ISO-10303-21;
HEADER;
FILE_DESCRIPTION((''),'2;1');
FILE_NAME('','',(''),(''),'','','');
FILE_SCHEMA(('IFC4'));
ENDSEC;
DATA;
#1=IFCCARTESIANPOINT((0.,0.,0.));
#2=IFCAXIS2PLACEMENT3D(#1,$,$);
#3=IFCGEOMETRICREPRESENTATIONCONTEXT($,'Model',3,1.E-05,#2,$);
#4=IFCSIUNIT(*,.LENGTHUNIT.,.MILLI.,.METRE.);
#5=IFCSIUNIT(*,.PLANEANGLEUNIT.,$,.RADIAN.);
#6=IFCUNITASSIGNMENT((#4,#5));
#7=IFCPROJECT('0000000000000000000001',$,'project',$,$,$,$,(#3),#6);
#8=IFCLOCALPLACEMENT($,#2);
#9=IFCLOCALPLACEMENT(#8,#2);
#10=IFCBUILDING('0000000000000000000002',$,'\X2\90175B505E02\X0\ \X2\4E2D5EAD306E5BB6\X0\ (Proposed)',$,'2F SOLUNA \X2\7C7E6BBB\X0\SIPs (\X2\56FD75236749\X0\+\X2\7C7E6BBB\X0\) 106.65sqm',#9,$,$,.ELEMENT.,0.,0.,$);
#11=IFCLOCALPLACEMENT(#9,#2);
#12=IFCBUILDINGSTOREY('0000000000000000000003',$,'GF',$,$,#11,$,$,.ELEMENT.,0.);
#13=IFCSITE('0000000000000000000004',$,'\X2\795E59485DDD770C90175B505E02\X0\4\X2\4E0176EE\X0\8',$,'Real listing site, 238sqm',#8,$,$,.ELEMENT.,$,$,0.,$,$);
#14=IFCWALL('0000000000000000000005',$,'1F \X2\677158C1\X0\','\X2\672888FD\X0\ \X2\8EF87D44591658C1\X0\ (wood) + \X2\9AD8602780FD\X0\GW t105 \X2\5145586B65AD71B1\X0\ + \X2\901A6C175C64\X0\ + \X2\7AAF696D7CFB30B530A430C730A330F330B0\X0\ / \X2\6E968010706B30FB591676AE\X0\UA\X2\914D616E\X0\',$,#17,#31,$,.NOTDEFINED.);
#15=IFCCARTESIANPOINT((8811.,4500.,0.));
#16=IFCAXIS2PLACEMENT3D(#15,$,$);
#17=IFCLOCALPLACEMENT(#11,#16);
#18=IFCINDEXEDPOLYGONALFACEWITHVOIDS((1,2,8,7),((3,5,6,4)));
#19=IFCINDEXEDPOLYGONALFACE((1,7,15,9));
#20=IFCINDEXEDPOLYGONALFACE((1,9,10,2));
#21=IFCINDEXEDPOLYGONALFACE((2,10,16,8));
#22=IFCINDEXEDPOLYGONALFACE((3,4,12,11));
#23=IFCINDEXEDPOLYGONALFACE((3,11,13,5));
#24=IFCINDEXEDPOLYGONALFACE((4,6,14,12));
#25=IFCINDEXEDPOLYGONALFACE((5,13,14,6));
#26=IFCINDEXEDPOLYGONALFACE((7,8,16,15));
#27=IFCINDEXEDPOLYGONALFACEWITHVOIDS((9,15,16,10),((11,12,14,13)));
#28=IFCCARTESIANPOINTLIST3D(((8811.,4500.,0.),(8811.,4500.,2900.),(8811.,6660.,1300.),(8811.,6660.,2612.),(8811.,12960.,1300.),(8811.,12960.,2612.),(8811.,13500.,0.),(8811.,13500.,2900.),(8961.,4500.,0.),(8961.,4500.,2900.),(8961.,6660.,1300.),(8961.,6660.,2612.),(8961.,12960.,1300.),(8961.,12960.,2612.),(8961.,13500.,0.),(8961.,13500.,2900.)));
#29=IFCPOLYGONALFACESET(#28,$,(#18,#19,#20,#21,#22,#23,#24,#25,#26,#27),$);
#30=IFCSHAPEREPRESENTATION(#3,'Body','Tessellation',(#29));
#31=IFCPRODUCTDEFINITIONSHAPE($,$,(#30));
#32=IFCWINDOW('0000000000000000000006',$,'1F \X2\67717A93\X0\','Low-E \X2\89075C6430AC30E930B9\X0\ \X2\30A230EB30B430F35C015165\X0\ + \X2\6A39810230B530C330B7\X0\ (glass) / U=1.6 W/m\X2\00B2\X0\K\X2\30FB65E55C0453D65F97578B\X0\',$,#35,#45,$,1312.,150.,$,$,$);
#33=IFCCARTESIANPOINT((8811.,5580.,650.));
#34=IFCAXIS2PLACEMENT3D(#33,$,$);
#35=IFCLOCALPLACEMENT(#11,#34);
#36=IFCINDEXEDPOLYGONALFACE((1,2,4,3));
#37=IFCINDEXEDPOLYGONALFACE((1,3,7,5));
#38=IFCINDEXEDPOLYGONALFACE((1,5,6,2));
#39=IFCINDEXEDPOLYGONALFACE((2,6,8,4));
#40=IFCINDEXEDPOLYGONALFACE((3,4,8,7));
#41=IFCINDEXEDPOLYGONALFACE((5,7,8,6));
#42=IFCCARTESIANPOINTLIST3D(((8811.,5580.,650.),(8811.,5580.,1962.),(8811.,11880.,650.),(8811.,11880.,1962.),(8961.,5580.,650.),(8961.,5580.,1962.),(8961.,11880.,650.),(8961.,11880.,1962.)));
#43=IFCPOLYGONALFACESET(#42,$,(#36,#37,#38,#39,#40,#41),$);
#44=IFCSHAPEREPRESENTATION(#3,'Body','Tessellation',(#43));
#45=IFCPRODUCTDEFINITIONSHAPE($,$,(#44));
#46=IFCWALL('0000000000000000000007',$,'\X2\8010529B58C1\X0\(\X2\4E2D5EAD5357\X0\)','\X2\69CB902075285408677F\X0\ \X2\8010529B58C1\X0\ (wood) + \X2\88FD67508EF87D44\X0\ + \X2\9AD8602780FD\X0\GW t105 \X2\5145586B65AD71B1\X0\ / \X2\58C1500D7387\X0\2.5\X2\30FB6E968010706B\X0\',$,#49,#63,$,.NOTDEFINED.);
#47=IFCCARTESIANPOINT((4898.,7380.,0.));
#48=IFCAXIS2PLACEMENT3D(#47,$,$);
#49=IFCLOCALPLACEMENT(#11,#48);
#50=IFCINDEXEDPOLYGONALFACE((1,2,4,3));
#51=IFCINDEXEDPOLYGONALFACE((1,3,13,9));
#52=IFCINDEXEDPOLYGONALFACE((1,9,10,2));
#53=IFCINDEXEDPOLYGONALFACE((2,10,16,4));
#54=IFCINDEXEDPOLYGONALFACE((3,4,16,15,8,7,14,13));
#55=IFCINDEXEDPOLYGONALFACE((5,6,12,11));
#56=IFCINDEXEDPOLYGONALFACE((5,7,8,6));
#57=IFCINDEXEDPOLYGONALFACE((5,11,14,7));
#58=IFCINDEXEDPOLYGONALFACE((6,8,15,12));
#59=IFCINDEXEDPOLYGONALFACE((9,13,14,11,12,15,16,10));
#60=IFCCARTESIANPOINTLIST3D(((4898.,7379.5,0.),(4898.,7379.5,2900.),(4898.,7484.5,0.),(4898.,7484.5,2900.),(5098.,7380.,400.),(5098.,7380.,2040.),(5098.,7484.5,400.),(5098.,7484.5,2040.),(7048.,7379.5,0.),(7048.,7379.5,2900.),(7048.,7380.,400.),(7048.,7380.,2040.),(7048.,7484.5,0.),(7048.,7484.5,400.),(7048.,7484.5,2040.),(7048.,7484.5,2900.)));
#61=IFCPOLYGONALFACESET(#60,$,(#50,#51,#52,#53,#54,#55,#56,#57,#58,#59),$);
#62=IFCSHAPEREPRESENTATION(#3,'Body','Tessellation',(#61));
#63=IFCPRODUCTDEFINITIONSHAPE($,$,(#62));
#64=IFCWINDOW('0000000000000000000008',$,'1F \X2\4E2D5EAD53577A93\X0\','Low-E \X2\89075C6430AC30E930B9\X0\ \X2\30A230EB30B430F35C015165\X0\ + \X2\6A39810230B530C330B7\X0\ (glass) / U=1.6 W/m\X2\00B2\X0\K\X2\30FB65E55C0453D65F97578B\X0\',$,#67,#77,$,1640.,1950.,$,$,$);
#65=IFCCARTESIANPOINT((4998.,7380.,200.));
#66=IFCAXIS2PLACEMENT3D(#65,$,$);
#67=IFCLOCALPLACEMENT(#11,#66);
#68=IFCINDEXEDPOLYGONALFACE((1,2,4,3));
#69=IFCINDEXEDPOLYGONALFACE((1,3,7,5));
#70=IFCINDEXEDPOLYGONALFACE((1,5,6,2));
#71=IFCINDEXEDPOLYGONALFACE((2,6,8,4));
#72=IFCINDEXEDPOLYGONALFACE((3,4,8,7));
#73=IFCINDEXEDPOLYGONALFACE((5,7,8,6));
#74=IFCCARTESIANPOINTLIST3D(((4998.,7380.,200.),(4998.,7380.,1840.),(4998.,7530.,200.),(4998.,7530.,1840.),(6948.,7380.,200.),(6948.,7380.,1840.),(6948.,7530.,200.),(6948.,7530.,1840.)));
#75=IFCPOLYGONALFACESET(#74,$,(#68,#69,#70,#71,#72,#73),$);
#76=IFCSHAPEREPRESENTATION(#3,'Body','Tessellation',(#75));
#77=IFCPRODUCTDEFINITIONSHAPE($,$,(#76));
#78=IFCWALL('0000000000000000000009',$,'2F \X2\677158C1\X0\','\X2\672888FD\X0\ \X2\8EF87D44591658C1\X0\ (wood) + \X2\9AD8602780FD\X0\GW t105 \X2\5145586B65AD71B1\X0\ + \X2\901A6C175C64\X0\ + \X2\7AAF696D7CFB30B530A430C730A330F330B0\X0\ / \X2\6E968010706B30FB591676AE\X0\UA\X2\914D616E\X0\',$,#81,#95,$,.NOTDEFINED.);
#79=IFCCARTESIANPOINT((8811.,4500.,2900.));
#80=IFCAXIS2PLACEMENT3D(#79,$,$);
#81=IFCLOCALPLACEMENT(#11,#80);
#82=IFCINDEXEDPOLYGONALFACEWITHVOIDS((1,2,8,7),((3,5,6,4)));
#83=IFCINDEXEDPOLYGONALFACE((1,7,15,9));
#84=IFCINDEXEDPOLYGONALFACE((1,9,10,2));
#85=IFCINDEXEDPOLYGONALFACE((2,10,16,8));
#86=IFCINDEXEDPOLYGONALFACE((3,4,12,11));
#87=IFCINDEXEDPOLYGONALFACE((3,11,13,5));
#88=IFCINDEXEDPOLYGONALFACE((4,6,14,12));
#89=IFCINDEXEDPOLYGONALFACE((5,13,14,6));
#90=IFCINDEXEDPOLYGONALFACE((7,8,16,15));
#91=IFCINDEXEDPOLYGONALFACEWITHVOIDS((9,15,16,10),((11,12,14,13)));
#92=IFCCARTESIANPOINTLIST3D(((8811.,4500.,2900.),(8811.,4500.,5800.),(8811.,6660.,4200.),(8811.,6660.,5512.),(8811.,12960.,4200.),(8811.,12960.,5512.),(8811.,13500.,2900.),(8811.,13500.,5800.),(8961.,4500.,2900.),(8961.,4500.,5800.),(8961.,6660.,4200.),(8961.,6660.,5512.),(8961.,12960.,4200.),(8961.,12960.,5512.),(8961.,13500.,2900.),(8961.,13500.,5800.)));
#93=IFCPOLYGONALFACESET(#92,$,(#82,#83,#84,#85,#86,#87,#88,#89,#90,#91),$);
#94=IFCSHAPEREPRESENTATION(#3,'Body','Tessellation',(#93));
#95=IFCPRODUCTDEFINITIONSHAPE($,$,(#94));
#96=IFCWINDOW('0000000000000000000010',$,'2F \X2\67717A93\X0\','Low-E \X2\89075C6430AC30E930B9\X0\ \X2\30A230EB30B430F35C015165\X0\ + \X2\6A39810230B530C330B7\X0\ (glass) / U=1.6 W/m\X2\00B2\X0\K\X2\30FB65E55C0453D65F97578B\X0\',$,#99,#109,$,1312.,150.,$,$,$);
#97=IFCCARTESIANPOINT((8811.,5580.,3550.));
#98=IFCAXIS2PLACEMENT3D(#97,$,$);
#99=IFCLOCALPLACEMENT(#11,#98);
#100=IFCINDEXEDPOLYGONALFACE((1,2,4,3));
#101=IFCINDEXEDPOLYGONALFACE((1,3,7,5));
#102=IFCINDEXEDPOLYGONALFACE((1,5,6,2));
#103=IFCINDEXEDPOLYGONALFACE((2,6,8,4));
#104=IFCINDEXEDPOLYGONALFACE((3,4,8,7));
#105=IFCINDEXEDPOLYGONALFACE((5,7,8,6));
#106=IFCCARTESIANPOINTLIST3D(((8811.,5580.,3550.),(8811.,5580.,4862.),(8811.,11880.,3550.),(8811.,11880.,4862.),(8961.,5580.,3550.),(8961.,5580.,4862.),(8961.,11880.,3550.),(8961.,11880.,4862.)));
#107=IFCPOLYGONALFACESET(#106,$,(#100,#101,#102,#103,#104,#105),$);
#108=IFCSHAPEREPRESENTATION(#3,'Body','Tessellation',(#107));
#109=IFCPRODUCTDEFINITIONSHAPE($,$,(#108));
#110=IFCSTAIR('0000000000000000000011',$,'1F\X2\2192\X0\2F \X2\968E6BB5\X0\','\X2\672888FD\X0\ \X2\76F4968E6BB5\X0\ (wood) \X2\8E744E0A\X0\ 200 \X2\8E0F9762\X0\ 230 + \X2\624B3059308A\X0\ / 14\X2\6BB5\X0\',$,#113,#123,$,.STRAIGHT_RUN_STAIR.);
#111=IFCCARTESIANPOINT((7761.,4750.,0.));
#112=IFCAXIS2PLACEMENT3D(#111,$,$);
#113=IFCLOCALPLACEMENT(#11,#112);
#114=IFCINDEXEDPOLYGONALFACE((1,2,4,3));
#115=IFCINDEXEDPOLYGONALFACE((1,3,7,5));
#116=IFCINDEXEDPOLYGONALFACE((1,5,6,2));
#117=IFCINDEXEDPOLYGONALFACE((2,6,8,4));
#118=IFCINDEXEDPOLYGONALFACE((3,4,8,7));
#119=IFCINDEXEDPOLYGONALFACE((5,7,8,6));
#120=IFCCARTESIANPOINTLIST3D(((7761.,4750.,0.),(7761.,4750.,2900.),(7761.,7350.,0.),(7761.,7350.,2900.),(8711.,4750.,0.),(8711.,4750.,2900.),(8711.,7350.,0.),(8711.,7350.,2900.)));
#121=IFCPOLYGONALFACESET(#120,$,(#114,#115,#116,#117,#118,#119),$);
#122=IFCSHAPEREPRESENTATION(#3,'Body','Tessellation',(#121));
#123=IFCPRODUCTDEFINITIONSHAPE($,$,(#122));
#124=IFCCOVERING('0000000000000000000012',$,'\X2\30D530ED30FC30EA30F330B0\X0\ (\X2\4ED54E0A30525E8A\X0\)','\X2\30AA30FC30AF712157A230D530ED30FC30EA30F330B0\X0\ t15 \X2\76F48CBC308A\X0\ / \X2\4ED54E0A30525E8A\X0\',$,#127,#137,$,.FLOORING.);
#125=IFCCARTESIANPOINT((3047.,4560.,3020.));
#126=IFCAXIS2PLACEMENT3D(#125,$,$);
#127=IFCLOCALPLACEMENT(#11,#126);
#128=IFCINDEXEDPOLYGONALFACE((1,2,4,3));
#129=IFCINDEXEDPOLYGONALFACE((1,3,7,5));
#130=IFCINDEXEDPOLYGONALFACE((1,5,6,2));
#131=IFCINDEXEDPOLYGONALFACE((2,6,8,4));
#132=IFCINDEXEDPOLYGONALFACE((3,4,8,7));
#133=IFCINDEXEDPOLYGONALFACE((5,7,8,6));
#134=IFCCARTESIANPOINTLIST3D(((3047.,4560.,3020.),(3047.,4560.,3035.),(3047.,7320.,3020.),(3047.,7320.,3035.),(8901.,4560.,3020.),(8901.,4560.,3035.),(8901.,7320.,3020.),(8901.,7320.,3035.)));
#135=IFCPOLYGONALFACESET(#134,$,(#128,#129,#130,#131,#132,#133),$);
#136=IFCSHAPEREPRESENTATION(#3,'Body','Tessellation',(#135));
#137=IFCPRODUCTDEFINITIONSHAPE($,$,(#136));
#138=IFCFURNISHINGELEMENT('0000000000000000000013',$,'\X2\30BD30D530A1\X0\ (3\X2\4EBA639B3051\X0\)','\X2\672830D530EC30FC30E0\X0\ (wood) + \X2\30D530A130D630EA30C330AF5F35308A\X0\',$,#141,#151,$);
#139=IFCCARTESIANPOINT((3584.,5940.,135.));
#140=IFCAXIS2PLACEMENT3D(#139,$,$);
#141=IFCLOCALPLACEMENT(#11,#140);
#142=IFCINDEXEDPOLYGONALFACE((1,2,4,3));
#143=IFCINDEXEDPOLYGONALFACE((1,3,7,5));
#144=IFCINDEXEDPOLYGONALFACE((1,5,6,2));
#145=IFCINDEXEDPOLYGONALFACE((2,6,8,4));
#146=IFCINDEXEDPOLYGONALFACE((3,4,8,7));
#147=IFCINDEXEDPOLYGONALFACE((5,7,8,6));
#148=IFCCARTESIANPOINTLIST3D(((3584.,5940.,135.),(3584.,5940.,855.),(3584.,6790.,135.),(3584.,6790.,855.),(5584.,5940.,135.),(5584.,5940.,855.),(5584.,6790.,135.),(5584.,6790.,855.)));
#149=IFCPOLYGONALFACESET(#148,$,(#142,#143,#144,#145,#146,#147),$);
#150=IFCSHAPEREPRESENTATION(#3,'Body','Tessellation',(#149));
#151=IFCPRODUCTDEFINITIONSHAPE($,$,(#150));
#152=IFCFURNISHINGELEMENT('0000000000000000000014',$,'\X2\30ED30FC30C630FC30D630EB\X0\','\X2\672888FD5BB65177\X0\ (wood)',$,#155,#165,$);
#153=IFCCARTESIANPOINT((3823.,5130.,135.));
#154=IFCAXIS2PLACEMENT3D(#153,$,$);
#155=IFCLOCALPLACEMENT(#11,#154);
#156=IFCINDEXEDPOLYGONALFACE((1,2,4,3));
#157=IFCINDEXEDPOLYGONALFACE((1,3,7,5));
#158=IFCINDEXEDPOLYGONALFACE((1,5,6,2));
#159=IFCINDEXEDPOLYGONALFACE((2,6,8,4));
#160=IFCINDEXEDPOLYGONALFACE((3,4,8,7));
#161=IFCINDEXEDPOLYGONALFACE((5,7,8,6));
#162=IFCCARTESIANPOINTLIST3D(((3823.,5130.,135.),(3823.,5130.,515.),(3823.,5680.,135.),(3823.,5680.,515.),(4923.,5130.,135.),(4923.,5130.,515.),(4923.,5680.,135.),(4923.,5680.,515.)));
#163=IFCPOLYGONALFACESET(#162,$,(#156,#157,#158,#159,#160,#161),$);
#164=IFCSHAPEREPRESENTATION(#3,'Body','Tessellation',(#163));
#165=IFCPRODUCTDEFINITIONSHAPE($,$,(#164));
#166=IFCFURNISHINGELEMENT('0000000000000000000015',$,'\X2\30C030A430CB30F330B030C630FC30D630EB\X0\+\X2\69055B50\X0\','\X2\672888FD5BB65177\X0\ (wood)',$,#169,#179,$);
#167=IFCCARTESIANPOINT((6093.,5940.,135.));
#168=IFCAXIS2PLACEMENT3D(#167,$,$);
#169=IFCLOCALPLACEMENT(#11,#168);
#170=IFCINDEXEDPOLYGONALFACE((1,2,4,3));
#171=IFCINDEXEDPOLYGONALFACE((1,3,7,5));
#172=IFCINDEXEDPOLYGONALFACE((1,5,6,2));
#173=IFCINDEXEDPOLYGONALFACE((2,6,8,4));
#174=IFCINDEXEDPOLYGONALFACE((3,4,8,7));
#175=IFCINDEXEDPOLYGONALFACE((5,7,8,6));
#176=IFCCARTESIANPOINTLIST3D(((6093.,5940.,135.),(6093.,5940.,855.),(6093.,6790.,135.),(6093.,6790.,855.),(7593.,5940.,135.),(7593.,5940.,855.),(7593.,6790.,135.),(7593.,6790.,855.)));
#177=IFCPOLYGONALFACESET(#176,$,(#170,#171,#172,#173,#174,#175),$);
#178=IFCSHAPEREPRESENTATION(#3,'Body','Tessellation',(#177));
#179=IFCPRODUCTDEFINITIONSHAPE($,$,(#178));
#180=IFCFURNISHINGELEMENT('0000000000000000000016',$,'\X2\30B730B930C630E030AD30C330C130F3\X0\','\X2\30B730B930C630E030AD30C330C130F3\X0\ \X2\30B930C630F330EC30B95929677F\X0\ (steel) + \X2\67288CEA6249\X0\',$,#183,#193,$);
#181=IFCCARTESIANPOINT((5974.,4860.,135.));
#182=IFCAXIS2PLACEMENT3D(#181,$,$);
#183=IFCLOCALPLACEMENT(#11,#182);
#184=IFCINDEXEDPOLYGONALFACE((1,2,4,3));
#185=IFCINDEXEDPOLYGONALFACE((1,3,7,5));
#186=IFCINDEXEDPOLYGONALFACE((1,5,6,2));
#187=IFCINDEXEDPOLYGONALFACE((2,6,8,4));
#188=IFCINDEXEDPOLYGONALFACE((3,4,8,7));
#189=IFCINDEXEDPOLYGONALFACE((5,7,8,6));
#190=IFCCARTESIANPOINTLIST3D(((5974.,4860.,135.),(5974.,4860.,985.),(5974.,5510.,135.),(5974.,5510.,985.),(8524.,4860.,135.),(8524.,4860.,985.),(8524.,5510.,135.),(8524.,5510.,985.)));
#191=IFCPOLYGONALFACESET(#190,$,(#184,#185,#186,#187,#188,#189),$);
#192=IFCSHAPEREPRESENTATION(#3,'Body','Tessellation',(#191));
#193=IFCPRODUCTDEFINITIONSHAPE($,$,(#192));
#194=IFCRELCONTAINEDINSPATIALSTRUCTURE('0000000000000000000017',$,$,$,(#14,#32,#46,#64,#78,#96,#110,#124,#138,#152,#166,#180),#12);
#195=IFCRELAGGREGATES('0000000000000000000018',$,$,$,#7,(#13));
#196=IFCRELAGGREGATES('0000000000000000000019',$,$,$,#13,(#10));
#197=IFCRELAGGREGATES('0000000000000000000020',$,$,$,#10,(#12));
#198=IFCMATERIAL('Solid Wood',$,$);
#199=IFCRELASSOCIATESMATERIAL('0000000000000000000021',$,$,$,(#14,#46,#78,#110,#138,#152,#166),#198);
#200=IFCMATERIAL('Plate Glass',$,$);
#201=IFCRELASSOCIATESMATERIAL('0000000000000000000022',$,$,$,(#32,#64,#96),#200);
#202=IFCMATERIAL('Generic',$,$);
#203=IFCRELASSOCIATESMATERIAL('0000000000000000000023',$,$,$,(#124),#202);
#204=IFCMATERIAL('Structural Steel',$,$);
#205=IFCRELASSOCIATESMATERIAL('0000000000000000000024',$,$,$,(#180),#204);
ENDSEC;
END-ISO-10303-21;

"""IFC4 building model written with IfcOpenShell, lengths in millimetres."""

from ifc_helpers import new_model, si_unit, frame, frame_2d, origin, place, context, project, spatial, rectangle, extrude, material, element, fill, save


model = new_model("IFC4")

# Units and contexts
model_context = context("Model", 3, precision=1e-05, world=origin())
ifc_project = project(units=[si_unit("LENGTHUNIT", "METRE", prefix="MILLI"), si_unit("PLANEANGLEUNIT", "RADIAN")], contexts=[model_context])

# Site, building, storey
site_placement = place(None, origin())
site = spatial("IfcSite", under=ifc_project, at=site_placement, Name="神奈川県逗子市4丁目8", ObjectType="Real listing site, 238sqm", CompositionType="ELEMENT", RefElevation=0.0)
building_placement = place(site_placement, origin())
building = spatial("IfcBuilding", under=site, at=building_placement, Name="逗子市 中庭の家 (Proposed)", ObjectType="2F SOLUNA 籾殻SIPs (国産杉+籾殻) 106.65sqm", CompositionType="ELEMENT", ElevationOfRefHeight=0.0, ElevationOfTerrain=0.0)
storey_placement = place(building_placement, origin())
storey = spatial("IfcBuildingStorey", under=building, at=storey_placement, Name="GF", CompositionType="ELEMENT", Elevation=0.0)

# Shared definitions
ifc_material_1 = material(Name="Solid Wood")

# Walls, openings, windows
wall_1_placement = place(storey_placement, frame((8811.0, 4500.0, 0.0)))
wall_1 = element("IfcWall", 1, at=wall_1_placement, inside=storey, material=ifc_material_1, Name="1F 東壁", Description="木製 軸組外壁 (wood) + 高性能GW t105 充填断熱 + 通気層 + 窯業系サイディング / 準耐火・外皮UA配慮", PredefinedType="NOTDEFINED", context=model_context, shape_type="SweptSolid", body=[
    extrude(rectangle(XDim=150.0, YDim=9000.0, at=frame_2d((75.0, 4500.0))), frame((8811.0, 4500.0, 0.0)), (0.0, 0.0, 1.0), 2900.0),
])
opening_1_placement = place(storey_placement, frame((8811.0, 5580.0, 650.0)))
opening_1 = element("IfcOpeningElement", 2, at=opening_1_placement, cuts=wall_1, PredefinedType="NOTDEFINED", context=model_context, shape_type="SweptSolid", body=[
    extrude(rectangle(XDim=150.0, YDim=6300.0, at=frame_2d((75.0, 3150.0))), frame((8811.0, 5580.0, 650.0)), (0.0, 0.0, 1.0), 1312.0),
])
ifc_material_2 = material(Name="Plate Glass")
window_1_placement = place(storey_placement, frame((8811.0, 5580.0, 650.0)))
window_1 = element("IfcWindow", 3, at=window_1_placement, inside=storey, material=ifc_material_2, Name="1F 東窓", Description="Low-E 複層ガラス アルゴン封入 + 樹脂サッシ (glass) / U=1.6 W/m²K・日射取得型", OverallHeight=1312.0, OverallWidth=150.0, context=model_context, shape_type="SweptSolid", body=[
    extrude(rectangle(XDim=150.0, YDim=6300.0, at=frame_2d((75.0, 3150.0))), frame((8811.0, 5580.0, 650.0)), (0.0, 0.0, 1.0), 1312.0),
])
fill(opening_1, window_1)
wall_2_placement = place(storey_placement, frame((4898.0, 7380.0, 0.0)))
wall_2 = element("IfcWall", 4, at=wall_2_placement, inside=storey, material=ifc_material_1, Name="耐力壁(中庭南)", Description="構造用合板 耐力壁 (wood) + 製材軸組 + 高性能GW t105 充填断熱 / 壁倍率2.5・準耐火", PredefinedType="NOTDEFINED", context=model_context, shape_type="SweptSolid", body=[
    extrude(rectangle(XDim=2150.0, YDim=105.0, at=frame_2d((1075.0, 52.0))), frame((4898.0, 7380.0, 0.0)), (0.0, 0.0, 1.0), 2900.0),
])
opening_2_placement = place(storey_placement, frame((4998.0, 7380.0, 200.0)))
opening_2 = element("IfcOpeningElement", 5, at=opening_2_placement, cuts=wall_2, PredefinedType="NOTDEFINED", context=model_context, shape_type="SweptSolid", body=[
    extrude(rectangle(XDim=1950.0, YDim=150.0, at=frame_2d((975.0, 75.0))), frame((4998.0, 7380.0, 200.0)), (0.0, 0.0, 1.0), 1640.0),
])
window_2_placement = place(storey_placement, frame((4998.0, 7380.0, 200.0)))
window_2 = element("IfcWindow", 6, at=window_2_placement, inside=storey, material=ifc_material_2, Name="1F 中庭南窓", Description="Low-E 複層ガラス アルゴン封入 + 樹脂サッシ (glass) / U=1.6 W/m²K・日射取得型", OverallHeight=1640.0, OverallWidth=1950.0, context=model_context, shape_type="SweptSolid", body=[
    extrude(rectangle(XDim=1950.0, YDim=150.0, at=frame_2d((975.0, 75.0))), frame((4998.0, 7380.0, 200.0)), (0.0, 0.0, 1.0), 1640.0),
])
fill(opening_2, window_2)

# Wall, opening, window
wall_3_placement = place(storey_placement, frame((8811.0, 4500.0, 2900.0)))
wall_3 = element("IfcWall", 7, at=wall_3_placement, inside=storey, material=ifc_material_1, Name="2F 東壁", Description="木製 軸組外壁 (wood) + 高性能GW t105 充填断熱 + 通気層 + 窯業系サイディング / 準耐火・外皮UA配慮", PredefinedType="NOTDEFINED", context=model_context, shape_type="SweptSolid", body=[
    extrude(rectangle(XDim=150.0, YDim=9000.0, at=frame_2d((75.0, 4500.0))), frame((8811.0, 4500.0, 2900.0)), (0.0, 0.0, 1.0), 2900.0),
])
opening_3_placement = place(storey_placement, frame((8811.0, 5580.0, 3550.0)))
opening_3 = element("IfcOpeningElement", 8, at=opening_3_placement, cuts=wall_3, PredefinedType="NOTDEFINED", context=model_context, shape_type="SweptSolid", body=[
    extrude(rectangle(XDim=150.0, YDim=6300.0, at=frame_2d((75.0, 3150.0))), frame((8811.0, 5580.0, 3550.0)), (0.0, 0.0, 1.0), 1312.0),
])
window_3_placement = place(storey_placement, frame((8811.0, 5580.0, 3550.0)))
window_3 = element("IfcWindow", 9, at=window_3_placement, inside=storey, material=ifc_material_2, Name="2F 東窓", Description="Low-E 複層ガラス アルゴン封入 + 樹脂サッシ (glass) / U=1.6 W/m²K・日射取得型", OverallHeight=1312.0, OverallWidth=150.0, context=model_context, shape_type="SweptSolid", body=[
    extrude(rectangle(XDim=150.0, YDim=6300.0, at=frame_2d((75.0, 3150.0))), frame((8811.0, 5580.0, 3550.0)), (0.0, 0.0, 1.0), 1312.0),
])
fill(opening_3, window_3)

# Stair
stair_placement = place(storey_placement, frame((7761.0, 4750.0, 0.0)))
element("IfcStair", 10, at=stair_placement, inside=storey, material=ifc_material_1, Name="1F→2F 階段", Description="木製 直階段 (wood) 蹴上 200 踏面 230 + 手すり / 14段", PredefinedType="STRAIGHT_RUN_STAIR", context=model_context, shape_type="SweptSolid", body=[
    extrude(rectangle(XDim=950.0, YDim=2600.0, at=frame_2d((475.0, 1300.0))), frame((7761.0, 4750.0, 0.0)), (0.0, 0.0, 1.0), 2900.0),
])

# Covering
ifc_material_3 = material(Name="Generic")
covering_placement = place(storey_placement, frame((3047.0, 4560.0, 3020.0)))
element("IfcCovering", 11, at=covering_placement, inside=storey, material=ifc_material_3, Name="フローリング (仕上げ床)", Description="オーク無垢フローリング t15 直貼り / 仕上げ床", PredefinedType="FLOORING", context=model_context, shape_type="SweptSolid", body=[
    extrude(rectangle(XDim=5854.0, YDim=2760.0, at=frame_2d((2927.0, 1380.0))), frame((3047.0, 4560.0, 3020.0)), (0.0, 0.0, 1.0), 15.0),
])

# Furnishing elements
furnishing_1_placement = place(storey_placement, frame((3584.0, 5940.0, 135.0)))
element("IfcFurnishingElement", 12, at=furnishing_1_placement, inside=storey, material=ifc_material_1, Name="ソファ (3人掛け)", Description="木フレーム (wood) + ファブリック張り", context=model_context, shape_type="SweptSolid", body=[
    extrude(rectangle(XDim=2000.0, YDim=850.0, at=frame_2d((1000.0, 425.0))), frame((3584.0, 5940.0, 135.0)), (0.0, 0.0, 1.0), 720.0),
])
furnishing_2_placement = place(storey_placement, frame((3823.0, 5130.0, 135.0)))
element("IfcFurnishingElement", 13, at=furnishing_2_placement, inside=storey, material=ifc_material_1, Name="ローテーブル", Description="木製家具 (wood)", context=model_context, shape_type="SweptSolid", body=[
    extrude(rectangle(XDim=1100.0, YDim=550.0, at=frame_2d((550.0, 275.0))), frame((3823.0, 5130.0, 135.0)), (0.0, 0.0, 1.0), 380.0),
])
furnishing_3_placement = place(storey_placement, frame((6093.0, 5940.0, 135.0)))
element("IfcFurnishingElement", 14, at=furnishing_3_placement, inside=storey, material=ifc_material_1, Name="ダイニングテーブル+椅子", Description="木製家具 (wood)", context=model_context, shape_type="SweptSolid", body=[
    extrude(rectangle(XDim=1500.0, YDim=850.0, at=frame_2d((750.0, 425.0))), frame((6093.0, 5940.0, 135.0)), (0.0, 0.0, 1.0), 720.0),
])
ifc_material_4 = material(Name="Structural Steel")
furnishing_4_placement = place(storey_placement, frame((5974.0, 4860.0, 135.0)))
element("IfcFurnishingElement", 15, at=furnishing_4_placement, inside=storey, material=ifc_material_4, Name="システムキッチン", Description="システムキッチン ステンレス天板 (steel) + 木質扉", context=model_context, shape_type="SweptSolid", body=[
    extrude(rectangle(XDim=2550.0, YDim=650.0, at=frame_2d((1275.0, 325.0))), frame((5974.0, 4860.0, 135.0)), (0.0, 0.0, 1.0), 850.0),
])

save(model, "model.ifc")
